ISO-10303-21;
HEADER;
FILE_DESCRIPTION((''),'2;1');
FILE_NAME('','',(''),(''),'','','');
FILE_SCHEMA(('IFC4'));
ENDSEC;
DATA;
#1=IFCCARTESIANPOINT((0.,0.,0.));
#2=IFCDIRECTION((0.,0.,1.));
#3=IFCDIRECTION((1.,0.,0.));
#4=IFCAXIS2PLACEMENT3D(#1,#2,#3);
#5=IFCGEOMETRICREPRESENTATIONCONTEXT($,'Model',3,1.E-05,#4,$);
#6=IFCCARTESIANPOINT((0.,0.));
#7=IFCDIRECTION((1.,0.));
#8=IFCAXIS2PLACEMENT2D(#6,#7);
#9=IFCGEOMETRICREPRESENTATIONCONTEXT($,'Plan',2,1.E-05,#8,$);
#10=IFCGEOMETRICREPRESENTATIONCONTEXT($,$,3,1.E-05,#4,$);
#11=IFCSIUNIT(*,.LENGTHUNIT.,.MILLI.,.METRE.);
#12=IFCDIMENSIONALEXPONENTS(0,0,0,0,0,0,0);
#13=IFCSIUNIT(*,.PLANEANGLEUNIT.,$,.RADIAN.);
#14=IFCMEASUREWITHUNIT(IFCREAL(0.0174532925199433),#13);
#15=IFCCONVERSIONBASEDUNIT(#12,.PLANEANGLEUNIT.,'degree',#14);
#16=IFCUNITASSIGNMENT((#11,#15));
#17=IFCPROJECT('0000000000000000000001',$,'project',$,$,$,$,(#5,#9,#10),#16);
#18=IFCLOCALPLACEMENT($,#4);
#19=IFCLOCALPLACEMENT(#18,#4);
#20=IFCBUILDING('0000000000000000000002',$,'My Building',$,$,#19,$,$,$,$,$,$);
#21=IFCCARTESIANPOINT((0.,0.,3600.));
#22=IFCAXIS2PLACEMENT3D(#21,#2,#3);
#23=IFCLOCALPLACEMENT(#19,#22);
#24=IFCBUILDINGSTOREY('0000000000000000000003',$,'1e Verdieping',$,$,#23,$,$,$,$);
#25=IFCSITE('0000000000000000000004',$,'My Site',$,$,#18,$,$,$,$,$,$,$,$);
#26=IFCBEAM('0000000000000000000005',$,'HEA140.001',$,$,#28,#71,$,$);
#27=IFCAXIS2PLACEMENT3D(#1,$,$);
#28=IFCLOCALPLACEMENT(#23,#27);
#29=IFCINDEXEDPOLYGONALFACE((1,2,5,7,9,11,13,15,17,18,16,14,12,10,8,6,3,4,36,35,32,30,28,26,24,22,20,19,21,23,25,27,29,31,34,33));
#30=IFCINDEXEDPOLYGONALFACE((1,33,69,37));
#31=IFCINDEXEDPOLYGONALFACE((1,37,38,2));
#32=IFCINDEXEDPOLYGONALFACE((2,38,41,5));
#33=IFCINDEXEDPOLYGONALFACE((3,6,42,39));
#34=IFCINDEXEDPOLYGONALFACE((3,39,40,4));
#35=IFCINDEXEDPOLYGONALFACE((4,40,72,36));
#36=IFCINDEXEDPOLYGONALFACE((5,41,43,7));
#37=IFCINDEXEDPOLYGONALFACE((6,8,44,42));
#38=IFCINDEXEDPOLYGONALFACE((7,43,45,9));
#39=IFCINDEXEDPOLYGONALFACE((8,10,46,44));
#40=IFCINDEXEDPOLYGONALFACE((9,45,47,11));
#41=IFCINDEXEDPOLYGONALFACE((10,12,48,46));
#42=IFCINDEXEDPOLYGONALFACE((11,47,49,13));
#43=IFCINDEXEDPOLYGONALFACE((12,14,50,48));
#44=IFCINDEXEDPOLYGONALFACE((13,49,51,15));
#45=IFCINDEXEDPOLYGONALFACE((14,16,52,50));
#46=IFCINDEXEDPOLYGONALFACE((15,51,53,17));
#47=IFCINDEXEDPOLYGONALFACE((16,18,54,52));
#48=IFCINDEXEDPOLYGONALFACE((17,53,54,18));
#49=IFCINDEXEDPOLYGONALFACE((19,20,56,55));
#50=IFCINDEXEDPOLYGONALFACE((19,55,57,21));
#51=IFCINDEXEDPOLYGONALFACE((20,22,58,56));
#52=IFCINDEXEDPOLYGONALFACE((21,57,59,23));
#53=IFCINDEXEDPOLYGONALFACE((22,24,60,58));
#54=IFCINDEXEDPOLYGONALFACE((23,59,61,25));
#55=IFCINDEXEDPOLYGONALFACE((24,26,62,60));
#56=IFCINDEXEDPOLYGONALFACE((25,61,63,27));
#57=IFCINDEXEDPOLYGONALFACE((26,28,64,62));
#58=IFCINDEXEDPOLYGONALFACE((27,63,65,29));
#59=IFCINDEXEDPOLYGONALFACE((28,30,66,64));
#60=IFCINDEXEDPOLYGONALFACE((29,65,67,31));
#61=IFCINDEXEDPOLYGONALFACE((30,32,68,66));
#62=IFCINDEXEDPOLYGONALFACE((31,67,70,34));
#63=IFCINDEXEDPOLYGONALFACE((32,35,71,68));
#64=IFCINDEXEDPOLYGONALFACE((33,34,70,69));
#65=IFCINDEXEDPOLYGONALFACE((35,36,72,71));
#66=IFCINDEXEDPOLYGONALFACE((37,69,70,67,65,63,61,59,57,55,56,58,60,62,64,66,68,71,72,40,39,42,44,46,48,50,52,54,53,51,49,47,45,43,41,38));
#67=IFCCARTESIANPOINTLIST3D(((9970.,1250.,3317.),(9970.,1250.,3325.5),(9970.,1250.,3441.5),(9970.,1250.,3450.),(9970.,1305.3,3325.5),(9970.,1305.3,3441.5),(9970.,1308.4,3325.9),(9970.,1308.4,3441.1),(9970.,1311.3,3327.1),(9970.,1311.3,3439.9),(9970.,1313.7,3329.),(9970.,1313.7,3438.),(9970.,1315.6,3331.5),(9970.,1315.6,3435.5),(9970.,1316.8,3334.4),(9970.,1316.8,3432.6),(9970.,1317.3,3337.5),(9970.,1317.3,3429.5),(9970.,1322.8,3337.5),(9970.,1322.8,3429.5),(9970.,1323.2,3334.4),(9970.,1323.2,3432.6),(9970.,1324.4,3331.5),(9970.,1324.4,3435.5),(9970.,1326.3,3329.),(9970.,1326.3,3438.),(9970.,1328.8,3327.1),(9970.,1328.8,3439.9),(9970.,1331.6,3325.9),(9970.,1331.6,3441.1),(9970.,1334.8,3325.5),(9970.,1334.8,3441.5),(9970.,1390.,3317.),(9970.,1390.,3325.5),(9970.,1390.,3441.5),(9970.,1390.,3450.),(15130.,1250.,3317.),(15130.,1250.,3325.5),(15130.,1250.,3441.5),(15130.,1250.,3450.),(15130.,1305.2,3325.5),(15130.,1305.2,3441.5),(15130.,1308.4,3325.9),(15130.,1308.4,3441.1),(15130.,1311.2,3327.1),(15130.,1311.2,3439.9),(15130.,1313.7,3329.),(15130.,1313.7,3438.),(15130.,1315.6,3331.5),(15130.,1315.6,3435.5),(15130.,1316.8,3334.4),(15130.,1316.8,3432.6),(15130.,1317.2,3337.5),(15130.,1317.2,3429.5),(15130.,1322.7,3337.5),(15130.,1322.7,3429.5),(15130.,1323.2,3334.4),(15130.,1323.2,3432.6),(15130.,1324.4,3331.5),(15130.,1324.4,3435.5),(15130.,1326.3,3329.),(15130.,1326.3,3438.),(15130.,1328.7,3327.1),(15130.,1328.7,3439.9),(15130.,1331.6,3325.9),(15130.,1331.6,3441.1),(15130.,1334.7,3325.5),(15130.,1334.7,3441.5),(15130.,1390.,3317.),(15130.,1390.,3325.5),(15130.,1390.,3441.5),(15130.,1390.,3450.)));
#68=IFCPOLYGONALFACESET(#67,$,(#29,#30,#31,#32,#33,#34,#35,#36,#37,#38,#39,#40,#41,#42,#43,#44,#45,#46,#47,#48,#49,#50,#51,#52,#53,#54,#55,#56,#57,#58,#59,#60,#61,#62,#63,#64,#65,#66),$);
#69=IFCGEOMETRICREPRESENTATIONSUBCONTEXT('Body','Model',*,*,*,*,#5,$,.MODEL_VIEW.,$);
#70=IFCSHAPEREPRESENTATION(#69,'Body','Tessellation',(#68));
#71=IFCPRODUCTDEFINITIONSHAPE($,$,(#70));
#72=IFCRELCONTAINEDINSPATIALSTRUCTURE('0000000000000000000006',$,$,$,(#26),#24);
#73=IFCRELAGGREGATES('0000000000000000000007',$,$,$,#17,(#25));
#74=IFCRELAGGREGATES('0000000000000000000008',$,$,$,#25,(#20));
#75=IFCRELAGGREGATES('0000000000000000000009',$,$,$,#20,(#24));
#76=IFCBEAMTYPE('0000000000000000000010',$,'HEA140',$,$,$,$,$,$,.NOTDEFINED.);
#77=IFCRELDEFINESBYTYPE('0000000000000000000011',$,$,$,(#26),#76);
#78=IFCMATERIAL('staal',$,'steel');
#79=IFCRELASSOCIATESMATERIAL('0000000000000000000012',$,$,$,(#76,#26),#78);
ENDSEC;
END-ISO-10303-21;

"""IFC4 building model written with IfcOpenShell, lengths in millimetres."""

from ifc_helpers import new_model, entity, si_unit, converted_unit, frame, origin_with_axes, origin_2d_with_axis, place, context, subcontext, project, spatial, i_section, extrude, material, material_profile, profile_set, profile_usage, type_object, element, save


model = new_model("IFC4")

# Units and contexts
model_context = context("Model", 3, precision=1e-05, world=origin_with_axes())
plan_context = context("Plan", 2, precision=1e-05, world=origin_2d_with_axis())
context_of_model = context(None, 3, precision=1e-05, world=origin_with_axes())
body_context = subcontext(model_context, "Body", "Model", "MODEL_VIEW")
ifc_project = project(units=[si_unit("LENGTHUNIT", "METRE", prefix="MILLI"), converted_unit("PLANEANGLEUNIT", "degree", entity("IfcReal", 0.0174532925199433), si_unit("PLANEANGLEUNIT", "RADIAN"), dimensions=[0, 0, 0, 0, 0, 0, 0])], contexts=[model_context, plan_context, context_of_model])

# Site, building, storey
site_placement = place(None, origin_with_axes())
site = spatial("IfcSite", under=ifc_project, at=site_placement, Name="My Site")
building_placement = place(site_placement, origin_with_axes())
building = spatial("IfcBuilding", under=site, at=building_placement, Name="My Building")
storey_placement = place(building_placement, frame((0.0, 0.0, 3600.0), z_axis=(0.0, 0.0, 1.0), x_axis=(1.0, 0.0, 0.0)))
storey = spatial("IfcBuildingStorey", under=building, at=storey_placement, Name="1e Verdieping")

# Shared definitions
ifc_material_1 = material(Name="staal", Category="steel")

# Beam
ifc_material_profile_1 = material_profile(ifc_material_1, i_section(OverallWidth=140.0, OverallDepth=133.0, WebThickness=5.5, FlangeThickness=8.5, FilletRadius=12.0))
ifc_profile_set_1 = profile_set([ifc_material_profile_1], Name="HEA140")
beam_type_1 = type_object("IfcBeamType", Name="HEA140", PredefinedType="NOTDEFINED", material=ifc_profile_set_1)
ifc_profile_usage_1 = profile_usage(ifc_profile_set_1)
beam_1_placement = place(storey_placement, frame((9970.0, 1320.0, 3383.5), z_axis=(1.0, 0.0, 0.0), x_axis=(0.0, 1.0, 0.0)))
element("IfcBeam", 1, at=beam_1_placement, inside=storey, type_object=beam_type_1, material=ifc_profile_usage_1, Name="HEA140.001", context=body_context, shape_type="SweptSolid", body=[
    extrude(i_section(OverallWidth=140.0, OverallDepth=133.0, WebThickness=5.5, FlangeThickness=8.5, FilletRadius=12.0), origin_with_axes(), (0.0, 0.0, 1.0), 5160.0),
])

save(model, "model.ifc")
